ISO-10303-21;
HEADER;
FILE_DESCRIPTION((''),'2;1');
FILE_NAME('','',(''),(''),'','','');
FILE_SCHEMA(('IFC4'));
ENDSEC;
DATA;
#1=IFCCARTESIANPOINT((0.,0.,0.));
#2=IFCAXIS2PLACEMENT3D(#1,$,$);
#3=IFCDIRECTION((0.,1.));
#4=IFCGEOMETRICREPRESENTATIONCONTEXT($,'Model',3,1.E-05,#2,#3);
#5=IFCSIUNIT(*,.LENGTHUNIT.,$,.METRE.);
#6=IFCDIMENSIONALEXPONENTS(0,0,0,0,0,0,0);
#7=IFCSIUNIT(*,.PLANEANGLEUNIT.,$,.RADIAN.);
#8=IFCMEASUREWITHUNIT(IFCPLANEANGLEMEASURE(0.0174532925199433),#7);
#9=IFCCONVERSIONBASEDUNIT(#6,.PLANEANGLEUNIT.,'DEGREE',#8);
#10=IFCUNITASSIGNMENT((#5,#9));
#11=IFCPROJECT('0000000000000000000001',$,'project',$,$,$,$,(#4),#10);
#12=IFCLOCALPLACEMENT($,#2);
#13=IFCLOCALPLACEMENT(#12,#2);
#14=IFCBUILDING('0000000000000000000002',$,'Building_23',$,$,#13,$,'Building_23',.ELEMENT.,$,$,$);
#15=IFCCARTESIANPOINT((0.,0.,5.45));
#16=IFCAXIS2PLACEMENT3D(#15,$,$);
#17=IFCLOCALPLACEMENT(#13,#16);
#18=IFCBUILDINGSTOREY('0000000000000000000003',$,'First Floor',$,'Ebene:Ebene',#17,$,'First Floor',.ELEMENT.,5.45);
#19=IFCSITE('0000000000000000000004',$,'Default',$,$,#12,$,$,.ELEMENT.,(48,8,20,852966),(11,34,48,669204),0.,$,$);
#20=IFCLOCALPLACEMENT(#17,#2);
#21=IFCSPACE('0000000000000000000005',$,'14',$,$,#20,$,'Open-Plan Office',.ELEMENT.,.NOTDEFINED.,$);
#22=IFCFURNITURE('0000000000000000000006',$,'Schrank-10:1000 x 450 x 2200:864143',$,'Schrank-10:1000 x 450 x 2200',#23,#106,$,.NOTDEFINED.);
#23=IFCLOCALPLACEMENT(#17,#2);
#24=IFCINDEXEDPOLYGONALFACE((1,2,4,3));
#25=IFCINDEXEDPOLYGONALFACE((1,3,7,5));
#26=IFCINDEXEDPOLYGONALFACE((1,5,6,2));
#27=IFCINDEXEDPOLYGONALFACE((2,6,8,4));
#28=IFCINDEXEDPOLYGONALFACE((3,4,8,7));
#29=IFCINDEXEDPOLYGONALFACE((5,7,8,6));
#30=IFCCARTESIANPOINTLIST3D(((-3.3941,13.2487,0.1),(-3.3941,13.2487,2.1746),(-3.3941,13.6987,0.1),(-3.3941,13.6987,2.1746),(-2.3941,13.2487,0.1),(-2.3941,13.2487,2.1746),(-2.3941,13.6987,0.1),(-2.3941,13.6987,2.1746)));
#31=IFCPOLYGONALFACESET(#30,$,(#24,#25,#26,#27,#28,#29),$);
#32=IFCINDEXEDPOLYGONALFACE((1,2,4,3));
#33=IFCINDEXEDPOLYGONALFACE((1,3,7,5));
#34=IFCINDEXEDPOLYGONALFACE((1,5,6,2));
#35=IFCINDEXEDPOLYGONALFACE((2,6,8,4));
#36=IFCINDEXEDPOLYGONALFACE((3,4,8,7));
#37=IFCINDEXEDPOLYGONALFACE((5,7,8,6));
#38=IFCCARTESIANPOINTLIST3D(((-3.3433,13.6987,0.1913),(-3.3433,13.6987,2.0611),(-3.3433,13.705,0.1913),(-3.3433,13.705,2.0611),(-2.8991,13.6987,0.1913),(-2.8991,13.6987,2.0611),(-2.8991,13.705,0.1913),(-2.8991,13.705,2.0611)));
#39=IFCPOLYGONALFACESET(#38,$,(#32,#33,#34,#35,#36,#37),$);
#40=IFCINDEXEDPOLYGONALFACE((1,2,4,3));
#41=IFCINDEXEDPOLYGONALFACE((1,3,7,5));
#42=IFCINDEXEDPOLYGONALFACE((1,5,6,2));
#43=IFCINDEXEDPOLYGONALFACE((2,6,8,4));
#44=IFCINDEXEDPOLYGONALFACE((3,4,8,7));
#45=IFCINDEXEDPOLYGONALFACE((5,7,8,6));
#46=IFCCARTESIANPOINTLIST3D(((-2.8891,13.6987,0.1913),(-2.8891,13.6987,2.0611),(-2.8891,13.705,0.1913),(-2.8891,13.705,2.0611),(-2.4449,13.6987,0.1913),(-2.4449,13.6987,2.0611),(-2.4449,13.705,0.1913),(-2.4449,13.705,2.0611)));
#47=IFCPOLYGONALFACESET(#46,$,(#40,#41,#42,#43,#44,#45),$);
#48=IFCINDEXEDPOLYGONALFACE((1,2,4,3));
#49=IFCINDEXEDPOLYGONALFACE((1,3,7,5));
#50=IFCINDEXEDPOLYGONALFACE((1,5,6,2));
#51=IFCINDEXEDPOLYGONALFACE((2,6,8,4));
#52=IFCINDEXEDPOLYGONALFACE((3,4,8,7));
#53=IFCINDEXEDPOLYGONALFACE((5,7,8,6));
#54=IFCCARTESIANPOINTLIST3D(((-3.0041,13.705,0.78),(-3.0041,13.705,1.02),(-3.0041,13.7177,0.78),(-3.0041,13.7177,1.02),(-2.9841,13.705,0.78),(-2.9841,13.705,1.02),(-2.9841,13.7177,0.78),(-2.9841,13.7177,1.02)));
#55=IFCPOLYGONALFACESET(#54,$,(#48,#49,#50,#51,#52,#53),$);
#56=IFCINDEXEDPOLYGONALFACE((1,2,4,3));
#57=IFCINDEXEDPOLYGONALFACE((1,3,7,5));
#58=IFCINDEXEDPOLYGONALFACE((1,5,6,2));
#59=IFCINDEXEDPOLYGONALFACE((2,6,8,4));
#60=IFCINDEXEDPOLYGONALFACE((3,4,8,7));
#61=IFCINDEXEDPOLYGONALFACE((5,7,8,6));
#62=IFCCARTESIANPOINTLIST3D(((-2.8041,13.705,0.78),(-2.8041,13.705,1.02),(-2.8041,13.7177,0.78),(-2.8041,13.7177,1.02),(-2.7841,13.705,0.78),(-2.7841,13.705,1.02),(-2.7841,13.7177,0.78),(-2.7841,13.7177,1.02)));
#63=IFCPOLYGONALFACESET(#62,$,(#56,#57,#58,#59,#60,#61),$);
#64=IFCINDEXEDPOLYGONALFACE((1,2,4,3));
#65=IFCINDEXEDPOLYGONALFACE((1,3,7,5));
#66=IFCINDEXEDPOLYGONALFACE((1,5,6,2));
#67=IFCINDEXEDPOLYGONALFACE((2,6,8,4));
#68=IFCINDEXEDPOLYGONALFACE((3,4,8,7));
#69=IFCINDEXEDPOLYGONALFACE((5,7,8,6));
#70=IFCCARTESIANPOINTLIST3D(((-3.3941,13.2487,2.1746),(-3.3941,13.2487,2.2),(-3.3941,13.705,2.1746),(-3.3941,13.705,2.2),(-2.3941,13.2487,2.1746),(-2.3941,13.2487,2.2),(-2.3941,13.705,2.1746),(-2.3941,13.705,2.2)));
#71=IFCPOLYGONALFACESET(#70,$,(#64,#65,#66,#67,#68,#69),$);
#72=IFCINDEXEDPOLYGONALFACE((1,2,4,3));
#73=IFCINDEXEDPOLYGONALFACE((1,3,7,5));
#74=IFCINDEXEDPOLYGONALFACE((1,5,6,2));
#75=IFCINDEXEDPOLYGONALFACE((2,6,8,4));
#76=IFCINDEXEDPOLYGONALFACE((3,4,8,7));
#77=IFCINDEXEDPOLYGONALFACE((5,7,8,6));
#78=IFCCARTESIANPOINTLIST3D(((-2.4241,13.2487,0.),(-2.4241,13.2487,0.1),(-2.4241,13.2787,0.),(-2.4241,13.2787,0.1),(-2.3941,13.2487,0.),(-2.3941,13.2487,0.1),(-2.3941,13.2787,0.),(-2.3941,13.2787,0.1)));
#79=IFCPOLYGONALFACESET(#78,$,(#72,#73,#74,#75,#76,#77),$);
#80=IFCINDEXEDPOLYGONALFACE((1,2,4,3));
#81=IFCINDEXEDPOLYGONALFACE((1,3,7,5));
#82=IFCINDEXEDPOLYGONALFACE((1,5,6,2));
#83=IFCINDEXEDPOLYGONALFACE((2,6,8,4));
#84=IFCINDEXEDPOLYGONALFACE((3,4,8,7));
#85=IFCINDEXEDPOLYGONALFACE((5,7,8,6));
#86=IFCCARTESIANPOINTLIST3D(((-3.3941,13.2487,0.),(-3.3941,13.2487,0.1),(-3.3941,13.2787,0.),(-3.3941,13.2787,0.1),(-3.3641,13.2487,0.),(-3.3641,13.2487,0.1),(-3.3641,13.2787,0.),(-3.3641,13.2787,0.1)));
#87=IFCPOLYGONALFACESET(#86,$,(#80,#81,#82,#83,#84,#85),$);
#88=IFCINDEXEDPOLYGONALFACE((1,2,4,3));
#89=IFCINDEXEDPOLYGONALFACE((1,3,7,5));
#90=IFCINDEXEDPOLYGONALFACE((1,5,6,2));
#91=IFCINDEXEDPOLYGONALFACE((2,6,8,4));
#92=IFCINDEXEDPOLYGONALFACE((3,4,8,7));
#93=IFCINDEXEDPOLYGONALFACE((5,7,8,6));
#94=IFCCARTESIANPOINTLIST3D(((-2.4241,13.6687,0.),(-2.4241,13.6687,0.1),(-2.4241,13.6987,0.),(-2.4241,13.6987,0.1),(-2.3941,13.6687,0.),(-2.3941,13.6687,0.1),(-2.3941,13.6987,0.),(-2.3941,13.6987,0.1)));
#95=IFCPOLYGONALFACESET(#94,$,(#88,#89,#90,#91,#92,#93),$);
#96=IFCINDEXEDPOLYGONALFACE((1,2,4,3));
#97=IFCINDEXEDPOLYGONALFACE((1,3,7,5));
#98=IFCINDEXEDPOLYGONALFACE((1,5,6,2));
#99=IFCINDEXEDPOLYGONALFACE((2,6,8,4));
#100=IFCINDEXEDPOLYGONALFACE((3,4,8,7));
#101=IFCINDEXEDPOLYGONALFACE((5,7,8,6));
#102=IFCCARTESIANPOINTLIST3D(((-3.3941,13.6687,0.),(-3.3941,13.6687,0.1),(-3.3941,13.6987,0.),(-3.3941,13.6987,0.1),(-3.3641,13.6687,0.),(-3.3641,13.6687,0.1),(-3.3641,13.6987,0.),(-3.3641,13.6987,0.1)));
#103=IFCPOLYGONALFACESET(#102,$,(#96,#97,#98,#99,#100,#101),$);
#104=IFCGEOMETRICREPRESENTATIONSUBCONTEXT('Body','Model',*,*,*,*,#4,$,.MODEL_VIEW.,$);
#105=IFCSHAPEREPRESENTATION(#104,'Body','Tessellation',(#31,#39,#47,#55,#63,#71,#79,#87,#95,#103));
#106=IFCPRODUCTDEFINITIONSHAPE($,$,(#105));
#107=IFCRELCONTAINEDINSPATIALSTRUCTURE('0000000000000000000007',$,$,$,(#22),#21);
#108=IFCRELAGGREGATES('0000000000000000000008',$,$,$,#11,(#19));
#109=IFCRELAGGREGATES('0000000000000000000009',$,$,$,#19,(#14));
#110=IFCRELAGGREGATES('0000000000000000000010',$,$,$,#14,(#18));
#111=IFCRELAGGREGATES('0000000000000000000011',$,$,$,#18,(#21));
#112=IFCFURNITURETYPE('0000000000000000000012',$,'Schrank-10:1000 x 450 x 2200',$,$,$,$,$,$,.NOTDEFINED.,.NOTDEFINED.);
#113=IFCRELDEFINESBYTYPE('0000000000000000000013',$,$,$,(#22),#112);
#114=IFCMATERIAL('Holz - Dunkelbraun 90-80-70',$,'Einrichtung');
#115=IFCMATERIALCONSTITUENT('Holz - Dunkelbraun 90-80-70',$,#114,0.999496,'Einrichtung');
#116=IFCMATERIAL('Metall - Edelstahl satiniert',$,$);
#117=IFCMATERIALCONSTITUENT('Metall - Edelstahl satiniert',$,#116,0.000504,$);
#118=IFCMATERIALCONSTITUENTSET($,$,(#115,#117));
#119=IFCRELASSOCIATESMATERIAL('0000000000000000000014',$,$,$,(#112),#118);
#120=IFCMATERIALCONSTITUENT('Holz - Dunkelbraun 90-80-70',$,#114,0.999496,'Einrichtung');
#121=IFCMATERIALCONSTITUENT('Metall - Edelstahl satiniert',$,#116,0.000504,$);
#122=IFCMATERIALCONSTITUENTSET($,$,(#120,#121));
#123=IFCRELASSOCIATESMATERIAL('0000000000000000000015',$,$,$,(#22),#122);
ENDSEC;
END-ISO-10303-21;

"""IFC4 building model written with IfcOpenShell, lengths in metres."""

from ifc_helpers import new_model, entity, si_unit, converted_unit, direction, frame, origin, place, context, subcontext, project, spatial, indexed_curve, outline, extrude, source, transform, mapped, material, constituent, constituent_set, type_object, type_shapes, element, save


model = new_model("IFC4")

# Units and contexts
model_context = context("Model", 3, precision=1e-05, world=origin(), true_north=direction((0.0, 1.0)))
body_context = subcontext(model_context, "Body", "Model", "MODEL_VIEW")
ifc_project = project(units=[si_unit("LENGTHUNIT", "METRE"), converted_unit("PLANEANGLEUNIT", "DEGREE", entity("IfcPlaneAngleMeasure", 0.0174532925199433), si_unit("PLANEANGLEUNIT", "RADIAN"), dimensions=[0, 0, 0, 0, 0, 0, 0])], contexts=[model_context])

# Site, building, storey
site_placement = place(None, origin())
site = spatial("IfcSite", under=ifc_project, at=site_placement, Name="Default", CompositionType="ELEMENT", RefLatitude=(48, 8, 20, 852966), RefLongitude=(11, 34, 48, 669204), RefElevation=0.0)
building_placement = place(site_placement, origin())
building = spatial("IfcBuilding", under=site, at=building_placement, Name="Building_23", LongName="Building_23", CompositionType="ELEMENT")
storey_placement = place(building_placement, frame((0.0, 0.0, 5.45)))
storey = spatial("IfcBuildingStorey", under=building, at=storey_placement, Name="First Floor", ObjectType="Ebene:Ebene", LongName="First Floor", CompositionType="ELEMENT", Elevation=5.45)

# Shared definitions
ifc_material_1 = material(Name="Holz - Dunkelbraun 90-80-70", Category="Einrichtung")
ifc_material_2 = material(Name="Metall - Edelstahl satiniert")
ifc_constituent_1 = constituent(ifc_material_1, Name="Holz - Dunkelbraun 90-80-70", Category="Einrichtung", fraction=0.999496)
ifc_constituent_2 = constituent(ifc_material_2, Name="Metall - Edelstahl satiniert", fraction=0.000504)
ifc_constituent_set_1 = constituent_set(constituents=[ifc_constituent_1, ifc_constituent_2])
furniture_type = type_object("IfcFurnitureType", Name="Schrank-10:1000 x 450 x 2200", AssemblyPlace="NOTDEFINED", PredefinedType="NOTDEFINED", material=ifc_constituent_set_1)
shared_shape_1 = source(origin(), body_context, "Body", "SweptSolid", [
    extrude(outline(indexed_curve([(-0.225, -0.5), (0.225, -0.5), (0.225, 0.5), (-0.225, 0.5), (-0.225, -0.5)], self_intersect=False)), frame((-0.2692, -0.3632, 0.1), z_axis=(0.0, 0.0, 1.0), x_axis=(0.0, 1.0, 0.0)), (0.0, 0.0, 1.0), 2.0746),
    extrude(outline(indexed_curve([(-0.0032, -0.2221), (0.0032, -0.2221), (0.0032, 0.2221), (-0.0032, 0.2221), (-0.0032, -0.2221)], self_intersect=False)), frame((-0.0421, -0.5913, 0.1913), z_axis=(0.0, 0.0, 1.0), x_axis=(0.0, 1.0, 0.0)), (0.0, 0.0, 1.0), 1.8698),
    extrude(outline(indexed_curve([(-0.0032, -0.2221), (0.0032, -0.2221), (0.0032, 0.2221), (-0.0032, 0.2221), (-0.0032, -0.2221)], self_intersect=False)), frame((-0.4963, -0.5913, 0.1913), z_axis=(0.0, 0.0, 1.0), x_axis=(0.0, 1.0, 0.0)), (0.0, 0.0, 1.0), 1.8698),
    extrude(outline(indexed_curve([(-0.0063, -0.01), (0.0063, -0.01), (0.0063, 0.01), (-0.0063, 0.01), (-0.0063, -0.01)], self_intersect=False)), frame((-0.1692, -0.6009, 0.78), z_axis=(0.0, 0.0, 1.0), x_axis=(0.0, 1.0, 0.0)), (0.0, 0.0, 1.0), 0.24),
    extrude(outline(indexed_curve([(-0.0063, -0.01), (0.0063, -0.01), (0.0063, 0.01), (-0.0063, 0.01), (-0.0063, -0.01)], self_intersect=False)), frame((-0.3692, -0.6009, 0.78), z_axis=(0.0, 0.0, 1.0), x_axis=(0.0, 1.0, 0.0)), (0.0, 0.0, 1.0), 0.24),
    extrude(outline(indexed_curve([(-0.5, -0.2282), (0.5, -0.2282), (0.5, 0.2282), (-0.5, 0.2282), (-0.5, -0.2282)], self_intersect=False)), frame((-0.2692, -0.3663, 2.1746), z_axis=(0.0, 0.0, 1.0), x_axis=(-1.0, 0.0, 0.0)), (0.0, 0.0, 1.0), 0.0254),
    extrude(outline(indexed_curve([(-0.015, -0.015), (0.015, -0.015), (0.015, 0.015), (-0.015, 0.015), (-0.015, -0.015)], self_intersect=False)), frame((-0.7542, -0.1532, 0.0), z_axis=(0.0, 0.0, 1.0), x_axis=(-1.0, 0.0, 0.0)), (0.0, 0.0, 1.0), 0.1),
    extrude(outline(indexed_curve([(-0.015, -0.015), (0.015, -0.015), (0.015, 0.015), (-0.015, 0.015), (-0.015, -0.015)], self_intersect=False)), frame((0.2158, -0.1532, 0.0), z_axis=(0.0, 0.0, 1.0), x_axis=(0.0, -1.0, 0.0)), (0.0, 0.0, 1.0), 0.1),
    extrude(outline(indexed_curve([(-0.015, -0.015), (0.015, -0.015), (0.015, 0.015), (-0.015, 0.015), (-0.015, -0.015)], self_intersect=False)), frame((-0.7542, -0.5732, 0.0), z_axis=(0.0, 0.0, 1.0), x_axis=(0.0, 1.0, 0.0)), (0.0, 0.0, 1.0), 0.1),
    extrude(outline(indexed_curve([(-0.015, -0.015), (0.015, -0.015), (0.015, 0.015), (-0.015, 0.015), (-0.015, -0.015)], self_intersect=False)), frame((0.2158, -0.5732, 0.0)), (0.0, 0.0, 1.0), 0.1),
])
type_shapes(furniture_type, [shared_shape_1])

# Shared definitions
space_1_placement = place(storey_placement, origin())
space_1 = spatial("IfcSpace", under=storey, at=space_1_placement, Name="14", LongName="Open-Plan Office", CompositionType="ELEMENT", PredefinedType="NOTDEFINED")

# Furniture
ifc_constituent_3 = constituent(ifc_material_1, Name="Holz - Dunkelbraun 90-80-70", Category="Einrichtung", fraction=0.999496)
ifc_constituent_4 = constituent(ifc_material_2, Name="Metall - Edelstahl satiniert", fraction=0.000504)
ifc_constituent_set_2 = constituent_set(constituents=[ifc_constituent_3, ifc_constituent_4])
furniture_1_placement = place(space_1_placement, frame((-3.1633, 13.1105, 0.0), z_axis=(0.0, 0.0, 1.0), x_axis=(-1.0, 0.0, 0.0)))
element("IfcFurniture", 1, at=furniture_1_placement, inside=space_1, type_object=furniture_type, material=ifc_constituent_set_2, Name="Schrank-10:1000 x 450 x 2200:864143", ObjectType="Schrank-10:1000 x 450 x 2200", PredefinedType="NOTDEFINED", context=body_context, shape_type="MappedRepresentation", body=[
    mapped(shared_shape_1, transform((0.0, 0.0, 0.0), scale=1.0)),
])

save(model, "model.ifc")
